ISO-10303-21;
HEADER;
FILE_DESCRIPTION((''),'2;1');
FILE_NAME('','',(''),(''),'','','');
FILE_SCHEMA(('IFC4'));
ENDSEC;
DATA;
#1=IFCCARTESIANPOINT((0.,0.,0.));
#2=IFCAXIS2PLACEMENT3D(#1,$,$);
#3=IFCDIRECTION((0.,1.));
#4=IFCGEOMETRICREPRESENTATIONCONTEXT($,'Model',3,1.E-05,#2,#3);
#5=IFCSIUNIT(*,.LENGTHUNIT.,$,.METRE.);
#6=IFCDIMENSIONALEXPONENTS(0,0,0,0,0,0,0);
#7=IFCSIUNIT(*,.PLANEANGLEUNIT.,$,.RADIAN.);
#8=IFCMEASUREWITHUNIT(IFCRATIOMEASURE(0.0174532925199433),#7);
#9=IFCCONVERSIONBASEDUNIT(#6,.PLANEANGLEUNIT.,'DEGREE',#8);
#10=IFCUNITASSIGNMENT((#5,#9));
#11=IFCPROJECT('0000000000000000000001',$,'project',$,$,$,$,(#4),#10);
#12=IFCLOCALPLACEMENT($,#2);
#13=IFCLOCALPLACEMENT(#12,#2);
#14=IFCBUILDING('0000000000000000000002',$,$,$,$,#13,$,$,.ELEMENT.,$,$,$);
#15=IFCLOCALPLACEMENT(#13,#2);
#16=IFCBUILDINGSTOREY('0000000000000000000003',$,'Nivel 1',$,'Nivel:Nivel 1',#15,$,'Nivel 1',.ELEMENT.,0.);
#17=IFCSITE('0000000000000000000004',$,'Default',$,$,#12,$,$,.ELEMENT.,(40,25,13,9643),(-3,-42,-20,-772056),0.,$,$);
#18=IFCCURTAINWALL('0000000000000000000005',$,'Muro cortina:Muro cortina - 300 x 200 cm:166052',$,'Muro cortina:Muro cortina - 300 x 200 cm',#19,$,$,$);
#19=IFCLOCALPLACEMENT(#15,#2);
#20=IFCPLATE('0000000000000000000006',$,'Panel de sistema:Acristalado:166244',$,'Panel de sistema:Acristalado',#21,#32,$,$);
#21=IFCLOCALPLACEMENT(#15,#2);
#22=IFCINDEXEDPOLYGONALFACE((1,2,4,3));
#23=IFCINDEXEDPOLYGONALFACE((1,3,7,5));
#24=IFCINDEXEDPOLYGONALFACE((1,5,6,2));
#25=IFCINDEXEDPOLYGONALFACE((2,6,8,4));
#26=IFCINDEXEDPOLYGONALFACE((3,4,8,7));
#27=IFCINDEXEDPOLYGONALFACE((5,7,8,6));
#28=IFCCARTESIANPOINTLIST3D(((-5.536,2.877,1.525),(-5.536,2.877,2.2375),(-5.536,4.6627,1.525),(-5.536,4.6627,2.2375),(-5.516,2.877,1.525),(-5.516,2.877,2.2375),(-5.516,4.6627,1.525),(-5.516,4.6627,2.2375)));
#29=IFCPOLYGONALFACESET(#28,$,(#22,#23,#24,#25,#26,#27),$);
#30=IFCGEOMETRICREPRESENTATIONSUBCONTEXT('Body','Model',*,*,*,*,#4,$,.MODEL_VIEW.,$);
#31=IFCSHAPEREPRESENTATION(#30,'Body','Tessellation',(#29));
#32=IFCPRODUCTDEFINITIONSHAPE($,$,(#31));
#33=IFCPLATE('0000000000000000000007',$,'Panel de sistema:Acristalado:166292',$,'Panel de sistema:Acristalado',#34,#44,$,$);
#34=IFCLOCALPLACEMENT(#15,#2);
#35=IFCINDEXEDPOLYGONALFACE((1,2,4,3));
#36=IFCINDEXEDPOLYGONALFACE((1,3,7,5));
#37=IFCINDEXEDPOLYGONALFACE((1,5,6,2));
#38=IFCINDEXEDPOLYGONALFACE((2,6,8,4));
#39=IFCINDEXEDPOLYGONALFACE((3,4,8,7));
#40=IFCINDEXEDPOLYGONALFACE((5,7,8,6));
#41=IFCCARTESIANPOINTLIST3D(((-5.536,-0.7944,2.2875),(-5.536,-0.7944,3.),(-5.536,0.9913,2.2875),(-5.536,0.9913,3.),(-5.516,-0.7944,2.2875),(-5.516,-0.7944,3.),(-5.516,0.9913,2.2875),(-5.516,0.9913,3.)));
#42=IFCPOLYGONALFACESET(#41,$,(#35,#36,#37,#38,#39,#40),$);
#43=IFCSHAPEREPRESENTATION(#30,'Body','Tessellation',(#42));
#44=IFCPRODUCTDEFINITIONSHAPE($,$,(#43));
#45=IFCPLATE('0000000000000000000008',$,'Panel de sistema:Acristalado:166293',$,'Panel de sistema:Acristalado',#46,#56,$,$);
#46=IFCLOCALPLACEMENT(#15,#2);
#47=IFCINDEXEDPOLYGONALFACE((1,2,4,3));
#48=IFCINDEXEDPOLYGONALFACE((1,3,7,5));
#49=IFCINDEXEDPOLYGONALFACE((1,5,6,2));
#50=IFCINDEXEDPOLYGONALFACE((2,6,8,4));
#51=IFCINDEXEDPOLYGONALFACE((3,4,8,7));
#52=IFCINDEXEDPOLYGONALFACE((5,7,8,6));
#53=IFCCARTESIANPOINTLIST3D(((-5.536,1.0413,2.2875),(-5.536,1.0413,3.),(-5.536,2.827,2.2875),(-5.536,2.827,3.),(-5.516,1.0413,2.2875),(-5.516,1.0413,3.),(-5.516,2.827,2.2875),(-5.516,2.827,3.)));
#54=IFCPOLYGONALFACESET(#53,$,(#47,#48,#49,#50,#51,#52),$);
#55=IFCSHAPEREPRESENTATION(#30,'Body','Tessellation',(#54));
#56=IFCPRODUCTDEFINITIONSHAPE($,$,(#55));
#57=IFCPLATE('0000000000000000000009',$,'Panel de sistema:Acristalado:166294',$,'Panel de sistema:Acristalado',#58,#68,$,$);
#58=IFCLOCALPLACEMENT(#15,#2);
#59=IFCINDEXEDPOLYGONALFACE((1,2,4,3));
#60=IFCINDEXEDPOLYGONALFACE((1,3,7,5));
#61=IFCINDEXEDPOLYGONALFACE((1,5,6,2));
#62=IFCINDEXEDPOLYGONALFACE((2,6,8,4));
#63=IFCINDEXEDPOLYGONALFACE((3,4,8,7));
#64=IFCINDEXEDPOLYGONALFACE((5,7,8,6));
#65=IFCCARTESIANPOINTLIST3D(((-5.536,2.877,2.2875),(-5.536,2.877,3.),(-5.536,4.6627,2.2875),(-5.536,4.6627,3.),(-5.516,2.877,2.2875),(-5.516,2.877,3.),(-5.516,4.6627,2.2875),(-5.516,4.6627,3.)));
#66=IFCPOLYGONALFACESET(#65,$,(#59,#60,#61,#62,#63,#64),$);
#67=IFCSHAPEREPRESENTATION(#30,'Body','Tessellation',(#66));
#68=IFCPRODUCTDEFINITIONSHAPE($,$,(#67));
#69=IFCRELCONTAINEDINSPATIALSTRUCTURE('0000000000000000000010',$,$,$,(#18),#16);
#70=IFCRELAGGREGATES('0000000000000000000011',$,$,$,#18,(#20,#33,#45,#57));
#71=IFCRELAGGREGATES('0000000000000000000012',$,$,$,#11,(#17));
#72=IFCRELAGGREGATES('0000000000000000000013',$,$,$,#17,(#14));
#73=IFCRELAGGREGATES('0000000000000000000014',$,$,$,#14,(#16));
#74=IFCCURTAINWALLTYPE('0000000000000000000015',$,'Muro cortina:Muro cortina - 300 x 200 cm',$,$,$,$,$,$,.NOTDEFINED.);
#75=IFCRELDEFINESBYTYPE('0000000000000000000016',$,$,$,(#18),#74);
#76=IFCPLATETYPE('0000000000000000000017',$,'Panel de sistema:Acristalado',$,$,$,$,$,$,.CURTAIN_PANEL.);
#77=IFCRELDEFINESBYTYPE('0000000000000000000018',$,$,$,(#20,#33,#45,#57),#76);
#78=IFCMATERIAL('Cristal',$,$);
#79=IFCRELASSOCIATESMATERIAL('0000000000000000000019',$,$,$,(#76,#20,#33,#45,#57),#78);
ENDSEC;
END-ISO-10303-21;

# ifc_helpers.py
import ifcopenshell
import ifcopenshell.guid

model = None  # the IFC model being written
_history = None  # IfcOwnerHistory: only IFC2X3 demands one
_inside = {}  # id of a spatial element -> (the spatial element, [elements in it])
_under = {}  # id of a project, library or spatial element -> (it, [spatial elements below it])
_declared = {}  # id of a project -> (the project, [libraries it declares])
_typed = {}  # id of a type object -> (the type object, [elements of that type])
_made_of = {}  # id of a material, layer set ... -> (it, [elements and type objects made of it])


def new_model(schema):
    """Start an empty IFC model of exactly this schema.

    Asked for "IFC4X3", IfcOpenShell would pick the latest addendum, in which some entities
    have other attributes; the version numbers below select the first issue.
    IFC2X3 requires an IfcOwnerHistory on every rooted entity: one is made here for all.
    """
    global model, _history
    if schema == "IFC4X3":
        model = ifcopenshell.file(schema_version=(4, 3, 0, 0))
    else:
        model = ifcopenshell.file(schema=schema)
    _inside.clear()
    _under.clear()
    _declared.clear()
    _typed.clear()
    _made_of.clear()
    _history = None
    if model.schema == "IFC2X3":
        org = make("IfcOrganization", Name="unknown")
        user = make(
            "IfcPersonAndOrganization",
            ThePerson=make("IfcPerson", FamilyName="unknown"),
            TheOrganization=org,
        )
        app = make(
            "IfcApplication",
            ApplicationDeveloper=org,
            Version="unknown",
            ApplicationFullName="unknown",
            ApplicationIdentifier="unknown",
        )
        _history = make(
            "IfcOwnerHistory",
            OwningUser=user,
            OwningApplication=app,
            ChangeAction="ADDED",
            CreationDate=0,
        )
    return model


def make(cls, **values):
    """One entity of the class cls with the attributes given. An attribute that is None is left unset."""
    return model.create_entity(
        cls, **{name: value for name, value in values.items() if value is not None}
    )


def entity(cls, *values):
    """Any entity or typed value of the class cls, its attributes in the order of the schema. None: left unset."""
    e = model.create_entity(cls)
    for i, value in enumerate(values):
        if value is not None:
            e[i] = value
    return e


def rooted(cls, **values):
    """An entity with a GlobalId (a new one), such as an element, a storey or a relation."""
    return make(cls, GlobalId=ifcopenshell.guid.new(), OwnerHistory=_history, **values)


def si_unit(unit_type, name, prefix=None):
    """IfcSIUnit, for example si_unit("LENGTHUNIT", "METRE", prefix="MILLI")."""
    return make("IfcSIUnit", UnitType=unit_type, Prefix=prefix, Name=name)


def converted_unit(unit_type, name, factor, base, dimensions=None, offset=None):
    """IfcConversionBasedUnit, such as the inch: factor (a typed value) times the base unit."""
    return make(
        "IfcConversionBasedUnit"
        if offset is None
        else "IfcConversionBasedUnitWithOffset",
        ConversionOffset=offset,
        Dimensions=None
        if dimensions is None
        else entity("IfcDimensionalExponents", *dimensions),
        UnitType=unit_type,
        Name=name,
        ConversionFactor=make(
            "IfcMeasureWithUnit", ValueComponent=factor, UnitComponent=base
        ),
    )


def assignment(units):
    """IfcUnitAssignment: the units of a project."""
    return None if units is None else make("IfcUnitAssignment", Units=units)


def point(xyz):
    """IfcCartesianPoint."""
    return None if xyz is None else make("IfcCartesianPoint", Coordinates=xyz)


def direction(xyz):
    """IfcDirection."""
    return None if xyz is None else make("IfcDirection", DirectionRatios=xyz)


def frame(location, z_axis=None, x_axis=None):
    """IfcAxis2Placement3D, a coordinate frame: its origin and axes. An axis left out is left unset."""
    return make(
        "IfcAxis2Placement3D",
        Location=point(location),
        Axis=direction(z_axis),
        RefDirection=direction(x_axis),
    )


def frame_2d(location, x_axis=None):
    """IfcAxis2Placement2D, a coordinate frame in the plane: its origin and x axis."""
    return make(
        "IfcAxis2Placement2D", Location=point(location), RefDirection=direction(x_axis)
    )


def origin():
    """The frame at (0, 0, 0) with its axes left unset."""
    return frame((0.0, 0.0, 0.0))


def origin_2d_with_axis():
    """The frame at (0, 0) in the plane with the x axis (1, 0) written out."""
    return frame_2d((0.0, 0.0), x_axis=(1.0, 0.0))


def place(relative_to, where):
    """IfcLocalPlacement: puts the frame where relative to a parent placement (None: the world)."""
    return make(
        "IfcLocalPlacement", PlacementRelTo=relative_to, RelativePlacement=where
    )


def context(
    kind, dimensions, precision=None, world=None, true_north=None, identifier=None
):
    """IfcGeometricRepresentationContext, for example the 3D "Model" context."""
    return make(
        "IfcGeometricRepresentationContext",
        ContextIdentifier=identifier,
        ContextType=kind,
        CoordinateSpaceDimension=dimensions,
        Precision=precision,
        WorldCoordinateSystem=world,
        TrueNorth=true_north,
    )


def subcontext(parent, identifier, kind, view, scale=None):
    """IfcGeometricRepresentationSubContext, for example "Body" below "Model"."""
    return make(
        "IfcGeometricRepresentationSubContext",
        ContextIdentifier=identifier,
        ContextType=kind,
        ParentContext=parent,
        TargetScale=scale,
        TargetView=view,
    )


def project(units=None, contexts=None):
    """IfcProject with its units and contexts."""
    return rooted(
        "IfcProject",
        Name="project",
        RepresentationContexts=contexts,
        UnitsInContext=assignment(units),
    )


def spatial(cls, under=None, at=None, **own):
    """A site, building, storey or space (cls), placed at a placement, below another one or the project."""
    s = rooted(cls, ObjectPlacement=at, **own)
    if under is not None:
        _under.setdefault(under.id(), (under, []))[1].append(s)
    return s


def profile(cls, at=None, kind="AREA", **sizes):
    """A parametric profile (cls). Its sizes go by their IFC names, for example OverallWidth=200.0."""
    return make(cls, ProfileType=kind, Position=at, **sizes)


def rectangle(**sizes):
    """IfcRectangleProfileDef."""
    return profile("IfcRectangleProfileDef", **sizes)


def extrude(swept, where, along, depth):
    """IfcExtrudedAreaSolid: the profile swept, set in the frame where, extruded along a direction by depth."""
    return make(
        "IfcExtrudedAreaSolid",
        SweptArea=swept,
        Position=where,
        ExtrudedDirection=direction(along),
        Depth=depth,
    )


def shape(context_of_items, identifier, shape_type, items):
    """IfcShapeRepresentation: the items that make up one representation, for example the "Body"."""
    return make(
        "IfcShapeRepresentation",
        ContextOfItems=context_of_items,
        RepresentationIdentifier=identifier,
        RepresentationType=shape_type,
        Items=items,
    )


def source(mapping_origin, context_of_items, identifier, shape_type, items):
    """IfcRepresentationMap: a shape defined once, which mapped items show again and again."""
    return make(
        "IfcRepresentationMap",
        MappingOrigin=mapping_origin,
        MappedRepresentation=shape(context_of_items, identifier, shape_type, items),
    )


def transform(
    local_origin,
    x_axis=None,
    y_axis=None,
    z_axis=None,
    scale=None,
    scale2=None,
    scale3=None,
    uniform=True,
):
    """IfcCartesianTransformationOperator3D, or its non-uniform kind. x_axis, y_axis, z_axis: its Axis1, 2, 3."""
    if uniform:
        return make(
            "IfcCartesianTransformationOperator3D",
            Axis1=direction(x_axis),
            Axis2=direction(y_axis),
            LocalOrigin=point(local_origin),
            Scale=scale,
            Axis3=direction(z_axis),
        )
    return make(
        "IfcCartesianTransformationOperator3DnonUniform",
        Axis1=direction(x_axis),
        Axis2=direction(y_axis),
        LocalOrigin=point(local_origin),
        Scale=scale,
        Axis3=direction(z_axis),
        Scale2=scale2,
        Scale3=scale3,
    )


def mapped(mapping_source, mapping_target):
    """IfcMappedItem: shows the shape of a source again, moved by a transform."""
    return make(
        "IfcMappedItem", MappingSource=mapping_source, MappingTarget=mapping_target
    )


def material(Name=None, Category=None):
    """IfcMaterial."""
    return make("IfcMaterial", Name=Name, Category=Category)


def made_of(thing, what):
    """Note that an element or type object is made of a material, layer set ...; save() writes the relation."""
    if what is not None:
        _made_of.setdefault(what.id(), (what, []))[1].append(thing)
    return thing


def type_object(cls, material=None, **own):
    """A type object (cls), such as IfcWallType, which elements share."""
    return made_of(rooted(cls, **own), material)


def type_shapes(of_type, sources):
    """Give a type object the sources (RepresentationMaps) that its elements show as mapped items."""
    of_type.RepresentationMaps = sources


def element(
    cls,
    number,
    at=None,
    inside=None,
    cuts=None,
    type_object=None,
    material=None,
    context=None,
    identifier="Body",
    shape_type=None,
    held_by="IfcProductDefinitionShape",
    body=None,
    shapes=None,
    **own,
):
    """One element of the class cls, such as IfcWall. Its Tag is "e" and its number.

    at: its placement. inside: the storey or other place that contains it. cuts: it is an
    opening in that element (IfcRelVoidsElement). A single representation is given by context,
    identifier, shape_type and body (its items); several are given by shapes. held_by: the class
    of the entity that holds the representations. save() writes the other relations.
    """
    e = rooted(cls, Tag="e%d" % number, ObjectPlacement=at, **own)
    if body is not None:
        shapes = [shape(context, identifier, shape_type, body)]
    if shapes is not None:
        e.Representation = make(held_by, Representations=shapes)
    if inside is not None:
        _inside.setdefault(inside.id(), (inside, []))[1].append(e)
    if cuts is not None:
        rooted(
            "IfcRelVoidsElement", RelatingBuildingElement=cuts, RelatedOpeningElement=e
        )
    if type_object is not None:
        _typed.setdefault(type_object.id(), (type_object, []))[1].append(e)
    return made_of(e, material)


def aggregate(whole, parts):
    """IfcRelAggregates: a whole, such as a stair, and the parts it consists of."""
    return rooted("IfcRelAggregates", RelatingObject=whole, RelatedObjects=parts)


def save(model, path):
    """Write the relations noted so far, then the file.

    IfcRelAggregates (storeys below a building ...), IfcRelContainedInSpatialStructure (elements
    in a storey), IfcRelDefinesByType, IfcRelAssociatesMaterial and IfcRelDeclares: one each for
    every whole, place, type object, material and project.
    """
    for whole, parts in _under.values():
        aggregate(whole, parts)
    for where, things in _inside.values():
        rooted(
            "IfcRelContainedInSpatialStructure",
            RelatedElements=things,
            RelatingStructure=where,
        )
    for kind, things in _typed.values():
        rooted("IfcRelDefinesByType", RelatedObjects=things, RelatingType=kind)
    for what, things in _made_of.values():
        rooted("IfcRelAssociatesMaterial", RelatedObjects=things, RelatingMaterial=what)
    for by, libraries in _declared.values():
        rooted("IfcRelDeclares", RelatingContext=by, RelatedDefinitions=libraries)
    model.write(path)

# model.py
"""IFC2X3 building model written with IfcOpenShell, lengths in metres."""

from ifc_helpers import new_model, entity, si_unit, converted_unit, direction, frame, origin, origin_2d_with_axis, place, context, subcontext, project, spatial, rectangle, extrude, source, transform, mapped, material, type_object, type_shapes, element, aggregate, save


model = new_model("IFC2X3")

# Units and contexts
model_context = context("Model", 3, precision=1e-05, world=origin(), true_north=direction((0.0, 1.0)))
body_context = subcontext(model_context, "Body", "Model", "MODEL_VIEW")
ifc_project = project(units=[si_unit("LENGTHUNIT", "METRE"), converted_unit("PLANEANGLEUNIT", "DEGREE", entity("IfcRatioMeasure", 0.0174532925199433), si_unit("PLANEANGLEUNIT", "RADIAN"), dimensions=[0, 0, 0, 0, 0, 0, 0])], contexts=[model_context])

# Site, building, storey
site_placement = place(None, origin())
site = spatial("IfcSite", under=ifc_project, at=site_placement, Name="Default", CompositionType="ELEMENT", RefLatitude=(40, 25, 13, 9643), RefLongitude=(-3, -42, -20, -772056), RefElevation=0.0)
building_placement = place(site_placement, origin())
building = spatial("IfcBuilding", under=site, at=building_placement, CompositionType="ELEMENT")
storey_placement = place(building_placement, origin())
storey = spatial("IfcBuildingStorey", under=building, at=storey_placement, Name="Nivel 1", ObjectType="Nivel:Nivel 1", LongName="Nivel 1", CompositionType="ELEMENT", Elevation=0.0)

# Curtain wall, plates
curtain_wall_type = type_object("IfcCurtainWallType", Name="Muro cortina:Muro cortina - 300 x 200 cm", PredefinedType="NOTDEFINED")
curtain_wall_placement = place(storey_placement, origin())
curtain_wall = element("IfcCurtainWall", 1, at=curtain_wall_placement, inside=storey, type_object=curtain_wall_type, Name="Muro cortina:Muro cortina - 300 x 200 cm:166052", ObjectType="Muro cortina:Muro cortina - 300 x 200 cm")
ifc_material_1 = material(Name="Cristal")
plate_type = type_object("IfcPlateType", Name="Panel de sistema:Acristalado", PredefinedType="CURTAIN_PANEL", material=ifc_material_1)
shared_shape_1 = source(origin(), body_context, "Body", "SweptSolid", [
    extrude(rectangle(XDim=0.02, YDim=1.7857, at=origin_2d_with_axis()), frame((0.0, 0.0, 0.0), z_axis=(0.0, 0.0, 1.0), x_axis=(0.0, 1.0, 0.0)), (0.0, 0.0, 1.0), 0.7125),
])
type_shapes(plate_type, [shared_shape_1])
plate_1_placement = place(curtain_wall_placement, frame((-5.526, 3.7699, 1.525), z_axis=(0.0, 0.0, 1.0), x_axis=(0.0, 1.0, 0.0)))
plate_1 = element("IfcPlate", 2, at=plate_1_placement, type_object=plate_type, material=ifc_material_1, Name="Panel de sistema:Acristalado:166244", ObjectType="Panel de sistema:Acristalado", context=body_context, shape_type="MappedRepresentation", body=[
    mapped(shared_shape_1, transform((0.0, 0.0, 0.0), scale=1.0)),
])
plate_2_placement = place(curtain_wall_placement, frame((-5.526, 0.0985, 2.2875), z_axis=(0.0, 0.0, 1.0), x_axis=(0.0, 1.0, 0.0)))
plate_2 = element("IfcPlate", 3, at=plate_2_placement, type_object=plate_type, material=ifc_material_1, Name="Panel de sistema:Acristalado:166292", ObjectType="Panel de sistema:Acristalado", context=body_context, shape_type="MappedRepresentation", body=[
    mapped(shared_shape_1, transform((0.0, 0.0, 0.0), scale=1.0)),
])
plate_3_placement = place(curtain_wall_placement, frame((-5.526, 1.9342, 2.2875), z_axis=(0.0, 0.0, 1.0), x_axis=(0.0, 1.0, 0.0)))
plate_3 = element("IfcPlate", 4, at=plate_3_placement, type_object=plate_type, material=ifc_material_1, Name="Panel de sistema:Acristalado:166293", ObjectType="Panel de sistema:Acristalado", context=body_context, shape_type="MappedRepresentation", body=[
    mapped(shared_shape_1, transform((0.0, 0.0, 0.0), scale=1.0)),
])
plate_4_placement = place(curtain_wall_placement, frame((-5.526, 3.7699, 2.2875), z_axis=(0.0, 0.0, 1.0), x_axis=(0.0, 1.0, 0.0)))
plate_4 = element("IfcPlate", 5, at=plate_4_placement, type_object=plate_type, material=ifc_material_1, Name="Panel de sistema:Acristalado:166294", ObjectType="Panel de sistema:Acristalado", context=body_context, shape_type="MappedRepresentation", body=[
    mapped(shared_shape_1, transform((0.0, 0.0, 0.0), scale=1.0)),
])
aggregate(curtain_wall, [plate_1, plate_2, plate_3, plate_4])

save(model, "model.ifc")
